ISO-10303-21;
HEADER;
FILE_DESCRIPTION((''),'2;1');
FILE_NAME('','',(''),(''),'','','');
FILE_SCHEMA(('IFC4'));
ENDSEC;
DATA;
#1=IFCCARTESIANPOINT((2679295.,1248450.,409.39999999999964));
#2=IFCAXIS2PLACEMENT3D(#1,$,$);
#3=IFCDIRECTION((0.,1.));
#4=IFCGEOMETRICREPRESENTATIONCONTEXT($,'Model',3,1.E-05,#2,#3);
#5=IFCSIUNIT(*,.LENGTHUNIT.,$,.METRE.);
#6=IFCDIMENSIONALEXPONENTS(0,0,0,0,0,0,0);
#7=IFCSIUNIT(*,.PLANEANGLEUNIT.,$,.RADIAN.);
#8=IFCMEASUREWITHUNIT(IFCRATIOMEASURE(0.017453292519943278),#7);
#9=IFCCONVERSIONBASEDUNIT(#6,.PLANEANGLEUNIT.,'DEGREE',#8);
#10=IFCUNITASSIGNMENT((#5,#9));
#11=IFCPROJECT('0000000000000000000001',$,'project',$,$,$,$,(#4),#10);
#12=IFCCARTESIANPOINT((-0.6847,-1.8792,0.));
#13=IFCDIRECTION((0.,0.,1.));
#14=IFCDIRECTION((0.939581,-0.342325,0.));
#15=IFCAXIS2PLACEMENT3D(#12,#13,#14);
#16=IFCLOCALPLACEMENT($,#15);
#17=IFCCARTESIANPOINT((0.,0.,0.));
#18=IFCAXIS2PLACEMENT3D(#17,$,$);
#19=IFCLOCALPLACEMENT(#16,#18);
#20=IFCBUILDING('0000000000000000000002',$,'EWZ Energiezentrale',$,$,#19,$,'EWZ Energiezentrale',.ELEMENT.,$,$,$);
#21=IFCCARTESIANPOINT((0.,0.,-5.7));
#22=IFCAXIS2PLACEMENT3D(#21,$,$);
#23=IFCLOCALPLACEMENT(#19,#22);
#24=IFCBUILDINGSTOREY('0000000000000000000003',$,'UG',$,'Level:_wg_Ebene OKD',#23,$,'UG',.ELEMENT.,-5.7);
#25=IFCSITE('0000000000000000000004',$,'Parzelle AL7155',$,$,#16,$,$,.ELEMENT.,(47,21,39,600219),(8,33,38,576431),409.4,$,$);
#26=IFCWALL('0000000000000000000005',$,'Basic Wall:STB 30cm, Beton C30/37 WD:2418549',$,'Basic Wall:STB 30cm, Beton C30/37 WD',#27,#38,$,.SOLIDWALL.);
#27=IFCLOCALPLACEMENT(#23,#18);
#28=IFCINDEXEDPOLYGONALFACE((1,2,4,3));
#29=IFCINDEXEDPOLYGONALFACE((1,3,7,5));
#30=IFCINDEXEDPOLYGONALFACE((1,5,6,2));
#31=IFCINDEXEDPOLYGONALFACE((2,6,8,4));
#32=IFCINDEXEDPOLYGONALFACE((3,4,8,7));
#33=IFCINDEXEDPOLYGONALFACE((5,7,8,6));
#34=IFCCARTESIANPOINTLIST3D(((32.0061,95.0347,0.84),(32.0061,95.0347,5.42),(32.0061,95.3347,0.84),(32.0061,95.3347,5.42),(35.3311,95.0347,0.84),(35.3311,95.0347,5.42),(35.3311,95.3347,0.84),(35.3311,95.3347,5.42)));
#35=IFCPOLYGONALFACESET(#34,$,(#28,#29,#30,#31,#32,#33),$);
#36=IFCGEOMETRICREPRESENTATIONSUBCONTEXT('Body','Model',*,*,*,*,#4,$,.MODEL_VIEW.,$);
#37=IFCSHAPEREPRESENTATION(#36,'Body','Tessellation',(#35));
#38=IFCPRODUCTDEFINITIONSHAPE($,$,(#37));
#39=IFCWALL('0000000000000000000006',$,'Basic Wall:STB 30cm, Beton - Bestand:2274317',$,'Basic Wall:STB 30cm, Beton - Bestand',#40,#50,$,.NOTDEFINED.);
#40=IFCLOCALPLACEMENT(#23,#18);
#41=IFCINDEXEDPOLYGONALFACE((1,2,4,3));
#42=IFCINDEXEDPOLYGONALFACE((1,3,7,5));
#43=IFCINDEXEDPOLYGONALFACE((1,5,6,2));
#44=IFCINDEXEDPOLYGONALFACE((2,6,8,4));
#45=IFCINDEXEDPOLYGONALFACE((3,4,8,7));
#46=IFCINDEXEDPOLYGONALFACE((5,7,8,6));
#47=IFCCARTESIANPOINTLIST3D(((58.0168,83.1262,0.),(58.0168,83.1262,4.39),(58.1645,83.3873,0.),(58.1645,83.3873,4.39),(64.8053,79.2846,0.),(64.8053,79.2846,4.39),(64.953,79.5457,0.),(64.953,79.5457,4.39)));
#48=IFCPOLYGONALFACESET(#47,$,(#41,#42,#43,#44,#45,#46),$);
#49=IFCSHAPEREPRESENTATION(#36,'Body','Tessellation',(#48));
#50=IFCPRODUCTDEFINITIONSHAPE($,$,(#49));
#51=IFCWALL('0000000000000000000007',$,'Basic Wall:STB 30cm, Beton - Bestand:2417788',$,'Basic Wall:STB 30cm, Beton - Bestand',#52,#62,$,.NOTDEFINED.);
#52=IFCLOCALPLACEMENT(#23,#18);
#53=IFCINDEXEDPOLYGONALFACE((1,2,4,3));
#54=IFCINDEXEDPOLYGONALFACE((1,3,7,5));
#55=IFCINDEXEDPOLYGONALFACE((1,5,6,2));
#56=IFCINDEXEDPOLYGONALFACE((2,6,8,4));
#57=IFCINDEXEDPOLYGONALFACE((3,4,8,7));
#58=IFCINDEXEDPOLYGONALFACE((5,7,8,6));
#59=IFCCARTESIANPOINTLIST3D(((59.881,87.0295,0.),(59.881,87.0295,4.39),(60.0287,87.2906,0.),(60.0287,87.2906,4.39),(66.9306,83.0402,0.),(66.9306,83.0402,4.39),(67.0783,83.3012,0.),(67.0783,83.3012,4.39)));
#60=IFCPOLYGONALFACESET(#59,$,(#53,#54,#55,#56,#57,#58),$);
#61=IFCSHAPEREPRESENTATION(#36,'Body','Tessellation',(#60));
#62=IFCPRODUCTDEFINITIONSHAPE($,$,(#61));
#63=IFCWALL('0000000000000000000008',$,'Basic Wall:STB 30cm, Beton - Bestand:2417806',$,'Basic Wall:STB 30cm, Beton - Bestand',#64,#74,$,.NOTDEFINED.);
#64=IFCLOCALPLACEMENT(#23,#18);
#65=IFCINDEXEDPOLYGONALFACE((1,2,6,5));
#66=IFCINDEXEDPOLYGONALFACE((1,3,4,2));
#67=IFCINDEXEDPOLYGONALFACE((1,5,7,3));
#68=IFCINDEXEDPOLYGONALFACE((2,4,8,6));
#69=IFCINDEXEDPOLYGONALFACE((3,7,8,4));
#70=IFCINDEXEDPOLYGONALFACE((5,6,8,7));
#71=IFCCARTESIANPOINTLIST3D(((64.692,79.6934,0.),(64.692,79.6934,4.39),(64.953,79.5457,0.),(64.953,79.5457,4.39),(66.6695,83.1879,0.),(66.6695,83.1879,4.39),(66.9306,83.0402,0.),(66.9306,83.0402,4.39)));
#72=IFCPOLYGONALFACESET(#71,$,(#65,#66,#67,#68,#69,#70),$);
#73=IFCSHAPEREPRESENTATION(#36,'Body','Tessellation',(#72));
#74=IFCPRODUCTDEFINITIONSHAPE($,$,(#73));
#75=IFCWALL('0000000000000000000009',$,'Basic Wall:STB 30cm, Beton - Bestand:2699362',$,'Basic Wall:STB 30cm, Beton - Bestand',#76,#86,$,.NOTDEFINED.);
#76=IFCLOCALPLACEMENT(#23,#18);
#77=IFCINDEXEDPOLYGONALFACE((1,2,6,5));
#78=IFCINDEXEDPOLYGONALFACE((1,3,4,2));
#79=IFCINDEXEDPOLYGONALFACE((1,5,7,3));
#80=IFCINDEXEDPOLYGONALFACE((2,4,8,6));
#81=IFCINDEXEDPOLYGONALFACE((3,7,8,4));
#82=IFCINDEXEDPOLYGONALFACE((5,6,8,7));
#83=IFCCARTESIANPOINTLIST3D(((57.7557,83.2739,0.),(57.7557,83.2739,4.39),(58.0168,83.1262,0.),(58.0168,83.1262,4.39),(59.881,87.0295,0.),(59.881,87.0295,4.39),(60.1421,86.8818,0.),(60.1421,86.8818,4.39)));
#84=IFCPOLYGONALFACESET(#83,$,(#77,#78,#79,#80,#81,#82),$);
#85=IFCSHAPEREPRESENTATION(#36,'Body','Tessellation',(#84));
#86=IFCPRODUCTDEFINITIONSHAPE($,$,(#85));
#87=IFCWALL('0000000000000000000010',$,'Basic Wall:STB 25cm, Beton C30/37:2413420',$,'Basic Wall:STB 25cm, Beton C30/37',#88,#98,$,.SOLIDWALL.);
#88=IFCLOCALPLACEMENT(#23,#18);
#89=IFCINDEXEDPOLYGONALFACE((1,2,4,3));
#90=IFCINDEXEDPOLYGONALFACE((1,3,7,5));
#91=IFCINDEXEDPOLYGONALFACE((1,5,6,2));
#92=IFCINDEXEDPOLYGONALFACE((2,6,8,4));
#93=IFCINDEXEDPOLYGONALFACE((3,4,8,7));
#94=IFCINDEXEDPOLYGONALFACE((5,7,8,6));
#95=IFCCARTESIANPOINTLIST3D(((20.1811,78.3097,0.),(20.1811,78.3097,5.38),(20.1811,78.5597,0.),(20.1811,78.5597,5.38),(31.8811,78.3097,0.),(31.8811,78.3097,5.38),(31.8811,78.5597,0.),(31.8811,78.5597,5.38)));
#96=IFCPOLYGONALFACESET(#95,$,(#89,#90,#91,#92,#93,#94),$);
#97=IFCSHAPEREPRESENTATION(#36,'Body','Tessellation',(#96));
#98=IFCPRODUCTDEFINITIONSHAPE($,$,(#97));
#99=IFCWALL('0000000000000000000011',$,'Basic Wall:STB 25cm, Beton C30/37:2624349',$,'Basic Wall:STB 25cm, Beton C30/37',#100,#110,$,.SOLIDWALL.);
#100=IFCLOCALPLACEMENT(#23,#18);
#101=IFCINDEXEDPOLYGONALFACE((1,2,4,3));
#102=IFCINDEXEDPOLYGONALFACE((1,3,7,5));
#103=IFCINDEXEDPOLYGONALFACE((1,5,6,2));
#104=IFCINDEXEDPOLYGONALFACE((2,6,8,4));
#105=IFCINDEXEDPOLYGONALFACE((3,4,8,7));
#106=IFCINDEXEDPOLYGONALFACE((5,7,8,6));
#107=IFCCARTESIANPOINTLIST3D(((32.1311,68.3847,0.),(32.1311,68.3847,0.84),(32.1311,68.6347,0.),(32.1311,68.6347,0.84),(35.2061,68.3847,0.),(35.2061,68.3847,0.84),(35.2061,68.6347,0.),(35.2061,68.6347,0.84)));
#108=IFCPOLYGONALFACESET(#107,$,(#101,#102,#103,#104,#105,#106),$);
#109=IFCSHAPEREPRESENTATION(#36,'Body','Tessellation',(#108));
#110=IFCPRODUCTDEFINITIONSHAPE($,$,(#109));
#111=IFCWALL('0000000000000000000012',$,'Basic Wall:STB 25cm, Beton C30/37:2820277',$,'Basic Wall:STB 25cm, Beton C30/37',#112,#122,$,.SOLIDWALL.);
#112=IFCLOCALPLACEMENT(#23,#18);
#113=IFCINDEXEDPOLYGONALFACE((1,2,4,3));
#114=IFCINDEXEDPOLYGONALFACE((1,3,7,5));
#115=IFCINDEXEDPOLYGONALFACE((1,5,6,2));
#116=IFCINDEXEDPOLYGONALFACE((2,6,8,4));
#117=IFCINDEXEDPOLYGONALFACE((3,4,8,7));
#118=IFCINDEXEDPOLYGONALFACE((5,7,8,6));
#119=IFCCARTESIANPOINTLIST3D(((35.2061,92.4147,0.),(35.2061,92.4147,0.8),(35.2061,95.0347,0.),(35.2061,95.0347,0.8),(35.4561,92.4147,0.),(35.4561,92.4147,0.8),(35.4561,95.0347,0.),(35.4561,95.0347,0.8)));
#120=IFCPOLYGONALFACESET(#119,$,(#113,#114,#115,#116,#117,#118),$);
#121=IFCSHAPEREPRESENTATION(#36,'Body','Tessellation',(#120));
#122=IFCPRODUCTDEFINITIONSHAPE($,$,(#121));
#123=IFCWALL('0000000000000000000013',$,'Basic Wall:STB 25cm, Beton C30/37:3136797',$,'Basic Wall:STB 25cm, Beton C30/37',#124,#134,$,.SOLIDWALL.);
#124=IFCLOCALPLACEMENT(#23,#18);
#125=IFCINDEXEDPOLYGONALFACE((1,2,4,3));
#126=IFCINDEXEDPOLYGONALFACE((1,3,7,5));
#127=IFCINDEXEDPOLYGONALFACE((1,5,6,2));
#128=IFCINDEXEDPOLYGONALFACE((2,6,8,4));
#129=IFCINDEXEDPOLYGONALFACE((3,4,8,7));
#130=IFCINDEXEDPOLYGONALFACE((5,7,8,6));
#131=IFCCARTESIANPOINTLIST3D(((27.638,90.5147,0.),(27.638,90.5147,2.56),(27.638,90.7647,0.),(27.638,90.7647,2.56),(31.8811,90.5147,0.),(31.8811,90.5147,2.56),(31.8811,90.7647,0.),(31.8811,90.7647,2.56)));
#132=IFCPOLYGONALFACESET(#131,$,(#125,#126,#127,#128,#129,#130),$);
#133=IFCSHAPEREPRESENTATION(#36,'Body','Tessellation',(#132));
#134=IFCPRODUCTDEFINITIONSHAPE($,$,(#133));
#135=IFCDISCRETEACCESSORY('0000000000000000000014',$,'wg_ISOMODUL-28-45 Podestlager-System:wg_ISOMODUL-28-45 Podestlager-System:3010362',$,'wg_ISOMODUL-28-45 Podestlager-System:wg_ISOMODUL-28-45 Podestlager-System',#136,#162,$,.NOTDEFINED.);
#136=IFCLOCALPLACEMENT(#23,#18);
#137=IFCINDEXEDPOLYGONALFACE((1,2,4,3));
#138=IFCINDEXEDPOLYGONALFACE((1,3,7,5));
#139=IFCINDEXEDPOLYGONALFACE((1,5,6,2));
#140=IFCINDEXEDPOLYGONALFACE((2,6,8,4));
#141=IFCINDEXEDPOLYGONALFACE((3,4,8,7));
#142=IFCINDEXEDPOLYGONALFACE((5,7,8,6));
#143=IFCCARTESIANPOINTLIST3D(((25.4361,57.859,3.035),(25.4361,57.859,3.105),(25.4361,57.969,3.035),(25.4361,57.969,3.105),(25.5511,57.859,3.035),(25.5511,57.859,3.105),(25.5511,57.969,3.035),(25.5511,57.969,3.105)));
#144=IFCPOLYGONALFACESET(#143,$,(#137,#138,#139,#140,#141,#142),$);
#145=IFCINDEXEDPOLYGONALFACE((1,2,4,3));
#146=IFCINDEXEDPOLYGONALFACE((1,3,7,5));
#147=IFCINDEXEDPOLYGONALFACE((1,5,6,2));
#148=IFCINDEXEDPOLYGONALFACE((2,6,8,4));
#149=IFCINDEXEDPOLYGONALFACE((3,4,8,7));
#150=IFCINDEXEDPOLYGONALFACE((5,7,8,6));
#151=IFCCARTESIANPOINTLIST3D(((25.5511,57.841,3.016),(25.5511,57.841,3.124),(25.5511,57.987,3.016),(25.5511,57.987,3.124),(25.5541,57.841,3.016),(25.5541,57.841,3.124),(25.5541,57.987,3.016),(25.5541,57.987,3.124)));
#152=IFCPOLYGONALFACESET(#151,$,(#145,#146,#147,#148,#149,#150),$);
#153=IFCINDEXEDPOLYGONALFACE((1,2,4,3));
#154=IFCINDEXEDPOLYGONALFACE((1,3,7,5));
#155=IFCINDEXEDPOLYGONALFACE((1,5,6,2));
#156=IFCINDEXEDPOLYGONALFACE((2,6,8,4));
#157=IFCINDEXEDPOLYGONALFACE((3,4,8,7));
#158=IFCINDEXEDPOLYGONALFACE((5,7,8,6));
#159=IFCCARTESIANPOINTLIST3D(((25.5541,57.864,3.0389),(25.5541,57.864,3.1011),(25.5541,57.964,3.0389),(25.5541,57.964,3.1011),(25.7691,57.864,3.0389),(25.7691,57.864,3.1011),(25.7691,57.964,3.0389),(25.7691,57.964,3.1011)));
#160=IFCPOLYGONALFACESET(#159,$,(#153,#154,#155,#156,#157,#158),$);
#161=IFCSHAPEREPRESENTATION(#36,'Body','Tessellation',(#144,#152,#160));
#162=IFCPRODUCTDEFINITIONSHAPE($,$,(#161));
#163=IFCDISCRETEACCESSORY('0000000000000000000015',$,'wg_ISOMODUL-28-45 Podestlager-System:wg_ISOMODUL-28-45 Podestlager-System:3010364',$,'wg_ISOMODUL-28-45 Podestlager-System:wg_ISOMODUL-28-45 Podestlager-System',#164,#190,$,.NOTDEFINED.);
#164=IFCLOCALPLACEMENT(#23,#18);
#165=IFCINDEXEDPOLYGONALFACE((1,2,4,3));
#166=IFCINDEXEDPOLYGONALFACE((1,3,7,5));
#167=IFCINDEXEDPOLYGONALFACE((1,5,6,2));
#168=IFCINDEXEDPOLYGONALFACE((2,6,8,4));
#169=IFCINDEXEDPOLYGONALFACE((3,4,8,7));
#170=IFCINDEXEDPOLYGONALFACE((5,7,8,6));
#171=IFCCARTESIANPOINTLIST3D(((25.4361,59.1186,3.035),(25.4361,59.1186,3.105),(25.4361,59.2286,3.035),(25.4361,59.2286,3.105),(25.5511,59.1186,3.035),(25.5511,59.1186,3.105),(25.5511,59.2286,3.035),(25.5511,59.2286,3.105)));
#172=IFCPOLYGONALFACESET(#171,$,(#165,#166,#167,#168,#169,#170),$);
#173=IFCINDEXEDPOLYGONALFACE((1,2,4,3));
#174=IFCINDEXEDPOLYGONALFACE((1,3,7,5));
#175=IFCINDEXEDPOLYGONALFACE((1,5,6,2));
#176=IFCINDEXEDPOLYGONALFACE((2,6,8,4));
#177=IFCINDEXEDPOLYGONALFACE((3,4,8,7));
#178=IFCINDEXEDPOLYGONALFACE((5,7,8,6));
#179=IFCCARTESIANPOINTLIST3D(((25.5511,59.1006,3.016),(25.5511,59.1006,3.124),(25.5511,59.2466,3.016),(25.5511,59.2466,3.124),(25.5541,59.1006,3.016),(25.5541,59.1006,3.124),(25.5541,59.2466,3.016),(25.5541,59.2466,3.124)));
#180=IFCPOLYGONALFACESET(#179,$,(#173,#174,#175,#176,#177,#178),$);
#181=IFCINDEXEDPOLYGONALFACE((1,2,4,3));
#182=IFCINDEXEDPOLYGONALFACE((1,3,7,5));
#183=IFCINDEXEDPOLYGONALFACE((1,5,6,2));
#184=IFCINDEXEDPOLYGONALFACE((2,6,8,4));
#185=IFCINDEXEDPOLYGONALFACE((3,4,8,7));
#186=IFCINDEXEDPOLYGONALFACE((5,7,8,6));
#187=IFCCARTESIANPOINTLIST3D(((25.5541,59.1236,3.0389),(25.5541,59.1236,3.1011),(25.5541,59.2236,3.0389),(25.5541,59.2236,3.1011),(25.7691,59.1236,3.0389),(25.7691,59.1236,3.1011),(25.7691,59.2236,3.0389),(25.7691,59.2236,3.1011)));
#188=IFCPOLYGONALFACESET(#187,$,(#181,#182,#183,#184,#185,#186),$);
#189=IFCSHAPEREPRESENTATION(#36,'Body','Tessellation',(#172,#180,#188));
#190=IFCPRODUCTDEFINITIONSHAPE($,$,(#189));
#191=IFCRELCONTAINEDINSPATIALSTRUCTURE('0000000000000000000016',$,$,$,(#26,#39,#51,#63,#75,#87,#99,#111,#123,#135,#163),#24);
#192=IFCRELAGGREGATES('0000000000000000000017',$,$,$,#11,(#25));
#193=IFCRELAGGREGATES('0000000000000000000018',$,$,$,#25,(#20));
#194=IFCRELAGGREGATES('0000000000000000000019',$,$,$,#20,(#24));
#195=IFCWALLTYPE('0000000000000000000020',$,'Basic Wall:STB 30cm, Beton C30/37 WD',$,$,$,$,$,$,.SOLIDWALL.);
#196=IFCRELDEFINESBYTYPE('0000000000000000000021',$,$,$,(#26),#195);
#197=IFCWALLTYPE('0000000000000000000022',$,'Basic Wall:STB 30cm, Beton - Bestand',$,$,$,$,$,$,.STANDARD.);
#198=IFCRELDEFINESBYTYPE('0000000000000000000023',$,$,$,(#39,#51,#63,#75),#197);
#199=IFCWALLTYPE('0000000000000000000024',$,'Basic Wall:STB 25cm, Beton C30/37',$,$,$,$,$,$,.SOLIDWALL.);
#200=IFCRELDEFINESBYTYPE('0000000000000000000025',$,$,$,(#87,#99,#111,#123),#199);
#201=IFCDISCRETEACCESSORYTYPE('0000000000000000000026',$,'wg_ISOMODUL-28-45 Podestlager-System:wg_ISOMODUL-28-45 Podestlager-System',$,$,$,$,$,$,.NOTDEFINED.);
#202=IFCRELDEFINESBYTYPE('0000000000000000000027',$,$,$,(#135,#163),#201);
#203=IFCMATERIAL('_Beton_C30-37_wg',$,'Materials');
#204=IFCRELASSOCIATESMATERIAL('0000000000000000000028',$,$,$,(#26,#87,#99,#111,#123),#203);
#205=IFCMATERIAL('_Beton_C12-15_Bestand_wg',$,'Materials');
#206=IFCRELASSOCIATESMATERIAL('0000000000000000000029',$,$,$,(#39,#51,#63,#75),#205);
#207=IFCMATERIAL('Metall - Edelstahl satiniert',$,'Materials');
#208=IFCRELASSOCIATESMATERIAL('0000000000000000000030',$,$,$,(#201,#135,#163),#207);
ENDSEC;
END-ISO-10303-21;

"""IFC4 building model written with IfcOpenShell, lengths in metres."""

from ifc_helpers import new_model, entity, si_unit, converted_unit, direction, frame, origin, place, context, subcontext, project, spatial, indexed_curve, outline, extrude, source, transform, mapped, material, type_object, type_shapes, element, save


model = new_model("IFC4")

# Units and contexts
model_context = context("Model", 3, precision=1e-05, world=frame((2679295.0, 1248450.0, 409.39999999999964)), true_north=direction((0.0, 1.0)))
body_context = subcontext(model_context, "Body", "Model", "MODEL_VIEW")
ifc_project = project(units=[si_unit("LENGTHUNIT", "METRE"), converted_unit("PLANEANGLEUNIT", "DEGREE", entity("IfcRatioMeasure", 0.017453292519943278), si_unit("PLANEANGLEUNIT", "RADIAN"), dimensions=[0, 0, 0, 0, 0, 0, 0])], contexts=[model_context])

# Site, building, storey
site_placement = place(None, frame((-0.6847, -1.8792, 0.0), z_axis=(0.0, 0.0, 1.0), x_axis=(0.939581, -0.342325, 0.0)))
site = spatial("IfcSite", under=ifc_project, at=site_placement, Name="Parzelle AL7155", CompositionType="ELEMENT", RefLatitude=(47, 21, 39, 600219), RefLongitude=(8, 33, 38, 576431), RefElevation=409.4)
building_placement = place(site_placement, origin())
building = spatial("IfcBuilding", under=site, at=building_placement, Name="EWZ Energiezentrale", LongName="EWZ Energiezentrale", CompositionType="ELEMENT")
storey_placement = place(building_placement, frame((0.0, 0.0, -5.7)))
storey = spatial("IfcBuildingStorey", under=building, at=storey_placement, Name="UG", ObjectType="Level:_wg_Ebene OKD", LongName="UG", CompositionType="ELEMENT", Elevation=-5.7)

# Shared definitions
ifc_material_1 = material(Name="_Beton_C30-37_wg", Category="Materials")

# Walls
wall_type_1 = type_object("IfcWallType", Name="Basic Wall:STB 30cm, Beton C30/37 WD", PredefinedType="SOLIDWALL")
wall_1_placement = place(storey_placement, frame((32.0061, 95.1847, 0.84)))
element("IfcWall", 1, at=wall_1_placement, inside=storey, type_object=wall_type_1, material=ifc_material_1, Name="Basic Wall:STB 30cm, Beton C30/37 WD:2418549", ObjectType="Basic Wall:STB 30cm, Beton C30/37 WD", PredefinedType="SOLIDWALL", context=body_context, shape_type="SweptSolid", body=[
    extrude(outline(indexed_curve([(3.325, 0.15), (0.0, 0.15), (0.0, -0.15), (3.325, -0.15), (3.325, 0.15)], self_intersect=False)), origin(), (0.0, 0.0, 1.0), 4.58),
])
ifc_material_2 = material(Name="_Beton_C12-15_Bestand_wg", Category="Materials")
wall_type_2 = type_object("IfcWallType", Name="Basic Wall:STB 30cm, Beton - Bestand", PredefinedType="STANDARD")
wall_2_placement = place(storey_placement, frame((58.0907, 83.2567, 0.0), z_axis=(0.0, 0.0, 1.0), x_axis=(0.870308, -0.492508, 0.0)))
element("IfcWall", 2, at=wall_2_placement, inside=storey, type_object=wall_type_2, material=ifc_material_2, Name="Basic Wall:STB 30cm, Beton - Bestand:2274317", ObjectType="Basic Wall:STB 30cm, Beton - Bestand", PredefinedType="NOTDEFINED", context=body_context, shape_type="SweptSolid", body=[
    extrude(outline(indexed_curve([(7.8001, 0.15), (0.0, 0.15), (0.0, -0.15), (7.8001, -0.15), (7.8001, 0.15)], self_intersect=False)), origin(), (0.0, 0.0, 1.0), 4.39),
])
wall_3_placement = place(storey_placement, frame((59.9549, 87.1601, 0.0), z_axis=(0.0, 0.0, 1.0), x_axis=(0.870308, -0.492508, 0.0)))
element("IfcWall", 3, at=wall_3_placement, inside=storey, type_object=wall_type_2, material=ifc_material_2, Name="Basic Wall:STB 30cm, Beton - Bestand:2417788", ObjectType="Basic Wall:STB 30cm, Beton - Bestand", PredefinedType="NOTDEFINED", context=body_context, shape_type="SweptSolid", body=[
    extrude(outline(indexed_curve([(8.1001, 0.15), (0.0, 0.15), (0.0, -0.15), (8.1001, -0.15), (8.1001, 0.15)], self_intersect=False)), origin(), (0.0, 0.0, 1.0), 4.39),
])
wall_4_placement = place(storey_placement, frame((64.8225, 79.6195, 0.0), z_axis=(0.0, 0.0, 1.0), x_axis=(0.492508, 0.870308, 0.0)))
element("IfcWall", 4, at=wall_4_placement, inside=storey, type_object=wall_type_2, material=ifc_material_2, Name="Basic Wall:STB 30cm, Beton - Bestand:2417806", ObjectType="Basic Wall:STB 30cm, Beton - Bestand", PredefinedType="NOTDEFINED", context=body_context, shape_type="SweptSolid", body=[
    extrude(outline(indexed_curve([(4.0152, 0.15), (0.0, 0.15), (0.0, -0.15), (4.0152, -0.15), (4.0152, 0.15)], self_intersect=False)), origin(), (0.0, 0.0, 1.0), 4.39),
])
wall_5_placement = place(storey_placement, frame((57.8862, 83.2001, 0.0), z_axis=(0.0, 0.0, 1.0), x_axis=(0.492508, 0.870308, 0.0)))
element("IfcWall", 5, at=wall_5_placement, inside=storey, type_object=wall_type_2, material=ifc_material_2, Name="Basic Wall:STB 30cm, Beton - Bestand:2699362", ObjectType="Basic Wall:STB 30cm, Beton - Bestand", PredefinedType="NOTDEFINED", context=body_context, shape_type="SweptSolid", body=[
    extrude(outline(indexed_curve([(4.3152, 0.15), (0.0, 0.15), (0.0, -0.15), (4.3152, -0.15), (4.3152, 0.15)], self_intersect=False)), origin(), (0.0, 0.0, 1.0), 4.39),
])
wall_type_3 = type_object("IfcWallType", Name="Basic Wall:STB 25cm, Beton C30/37", PredefinedType="SOLIDWALL")
wall_6_placement = place(storey_placement, frame((20.1811, 78.4347, 0.0)))
element("IfcWall", 6, at=wall_6_placement, inside=storey, type_object=wall_type_3, material=ifc_material_1, Name="Basic Wall:STB 25cm, Beton C30/37:2413420", ObjectType="Basic Wall:STB 25cm, Beton C30/37", PredefinedType="SOLIDWALL", context=body_context, shape_type="SweptSolid", body=[
    extrude(outline(indexed_curve([(11.7, 0.125), (0.0, 0.125), (0.0, -0.125), (11.7, -0.125), (11.7, 0.125)], self_intersect=False)), origin(), (0.0, 0.0, 1.0), 5.38),
])
wall_7_placement = place(storey_placement, frame((35.2061, 68.5097, 0.0), z_axis=(0.0, 0.0, 1.0), x_axis=(-1.0, 0.0, 0.0)))
element("IfcWall", 7, at=wall_7_placement, inside=storey, type_object=wall_type_3, material=ifc_material_1, Name="Basic Wall:STB 25cm, Beton C30/37:2624349", ObjectType="Basic Wall:STB 25cm, Beton C30/37", PredefinedType="SOLIDWALL", context=body_context, shape_type="SweptSolid", body=[
    extrude(outline(indexed_curve([(3.075, 0.125), (0.0, 0.125), (0.0, -0.125), (3.075, -0.125), (3.075, 0.125)], self_intersect=False)), origin(), (0.0, 0.0, 1.0), 0.84),
])
wall_8_placement = place(storey_placement, frame((35.3311, 92.4147, 0.0), z_axis=(0.0, 0.0, 1.0), x_axis=(0.0, 1.0, 0.0)))
element("IfcWall", 8, at=wall_8_placement, inside=storey, type_object=wall_type_3, material=ifc_material_1, Name="Basic Wall:STB 25cm, Beton C30/37:2820277", ObjectType="Basic Wall:STB 25cm, Beton C30/37", PredefinedType="SOLIDWALL", context=body_context, shape_type="SweptSolid", body=[
    extrude(outline(indexed_curve([(2.62, 0.125), (0.0, 0.125), (0.0, -0.125), (2.62, -0.125), (2.62, 0.125)], self_intersect=False)), origin(), (0.0, 0.0, 1.0), 0.8),
])
wall_9_placement = place(storey_placement, frame((27.638, 90.6397, 0.0)))
element("IfcWall", 9, at=wall_9_placement, inside=storey, type_object=wall_type_3, material=ifc_material_1, Name="Basic Wall:STB 25cm, Beton C30/37:3136797", ObjectType="Basic Wall:STB 25cm, Beton C30/37", PredefinedType="SOLIDWALL", context=body_context, shape_type="SweptSolid", body=[
    extrude(outline(indexed_curve([(4.243, 0.125), (0.0, 0.125), (0.0, -0.125), (4.243, -0.125), (4.243, 0.125)], self_intersect=False)), origin(), (0.0, 0.0, 1.0), 2.56),
])

# Discrete accessories
ifc_material_3 = material(Name="Metall - Edelstahl satiniert", Category="Materials")
discrete_accessory_type_1 = type_object("IfcDiscreteAccessoryType", Name="wg_ISOMODUL-28-45 Podestlager-System:wg_ISOMODUL-28-45 Podestlager-System", PredefinedType="NOTDEFINED", material=ifc_material_3)
shared_shape_1 = source(origin(), body_context, "Body", "SweptSolid", [
    extrude(outline(indexed_curve([(-0.055, -0.0575), (0.055, -0.0575), (0.055, 0.0575), (-0.055, 0.0575), (-0.055, -0.0575)], self_intersect=False)), frame((0.0, -0.0575, 0.0), z_axis=(0.0, 0.0, 1.0), x_axis=(-1.0, 0.0, 0.0)), (0.0, 0.0, 1.0), 0.07),
    extrude(outline(indexed_curve([(-0.073, -0.0015), (0.073, -0.0015), (0.073, 0.0015), (-0.073, 0.0015), (-0.073, -0.0015)], self_intersect=False)), frame((0.0, 0.0015, -0.019), z_axis=(0.0, 0.0, 1.0), x_axis=(-1.0, 0.0, 0.0)), (0.0, 0.0, 1.0), 0.108),
    extrude(outline(indexed_curve([(-0.05, -0.1075), (0.05, -0.1075), (0.05, 0.1075), (-0.05, 0.1075), (-0.05, -0.1075)], self_intersect=False)), frame((0.0, 0.1105, 0.0039), z_axis=(0.0, 0.0, 1.0), x_axis=(-1.0, 0.0, 0.0)), (0.0, 0.0, 1.0), 0.0621),
])
type_shapes(discrete_accessory_type_1, [shared_shape_1])
for number, where, z_axis, x_axis, name in (
    (10, (25.5511, 57.914, 3.035), (0.0, 0.0, 1.0), (0.0, -1.0, 0.0), "wg_ISOMODUL-28-45 Podestlager-System:wg_ISOMODUL-28-45 Podestlager-System:3010362"),
    (11, (25.5511, 59.1736, 3.035), (0.0, 0.0, 1.0), (0.0, -1.0, 0.0), "wg_ISOMODUL-28-45 Podestlager-System:wg_ISOMODUL-28-45 Podestlager-System:3010364"),
):
    element("IfcDiscreteAccessory", number, at=place(storey_placement, frame(where, z_axis=z_axis, x_axis=x_axis)), inside=storey, type_object=discrete_accessory_type_1, material=ifc_material_3, Name=name, ObjectType="wg_ISOMODUL-28-45 Podestlager-System:wg_ISOMODUL-28-45 Podestlager-System", PredefinedType="NOTDEFINED", context=body_context, shape_type="MappedRepresentation", body=[
        mapped(shared_shape_1, transform((0.0, 0.0, 0.0), scale=1.0)),
    ])

save(model, "model.ifc")
